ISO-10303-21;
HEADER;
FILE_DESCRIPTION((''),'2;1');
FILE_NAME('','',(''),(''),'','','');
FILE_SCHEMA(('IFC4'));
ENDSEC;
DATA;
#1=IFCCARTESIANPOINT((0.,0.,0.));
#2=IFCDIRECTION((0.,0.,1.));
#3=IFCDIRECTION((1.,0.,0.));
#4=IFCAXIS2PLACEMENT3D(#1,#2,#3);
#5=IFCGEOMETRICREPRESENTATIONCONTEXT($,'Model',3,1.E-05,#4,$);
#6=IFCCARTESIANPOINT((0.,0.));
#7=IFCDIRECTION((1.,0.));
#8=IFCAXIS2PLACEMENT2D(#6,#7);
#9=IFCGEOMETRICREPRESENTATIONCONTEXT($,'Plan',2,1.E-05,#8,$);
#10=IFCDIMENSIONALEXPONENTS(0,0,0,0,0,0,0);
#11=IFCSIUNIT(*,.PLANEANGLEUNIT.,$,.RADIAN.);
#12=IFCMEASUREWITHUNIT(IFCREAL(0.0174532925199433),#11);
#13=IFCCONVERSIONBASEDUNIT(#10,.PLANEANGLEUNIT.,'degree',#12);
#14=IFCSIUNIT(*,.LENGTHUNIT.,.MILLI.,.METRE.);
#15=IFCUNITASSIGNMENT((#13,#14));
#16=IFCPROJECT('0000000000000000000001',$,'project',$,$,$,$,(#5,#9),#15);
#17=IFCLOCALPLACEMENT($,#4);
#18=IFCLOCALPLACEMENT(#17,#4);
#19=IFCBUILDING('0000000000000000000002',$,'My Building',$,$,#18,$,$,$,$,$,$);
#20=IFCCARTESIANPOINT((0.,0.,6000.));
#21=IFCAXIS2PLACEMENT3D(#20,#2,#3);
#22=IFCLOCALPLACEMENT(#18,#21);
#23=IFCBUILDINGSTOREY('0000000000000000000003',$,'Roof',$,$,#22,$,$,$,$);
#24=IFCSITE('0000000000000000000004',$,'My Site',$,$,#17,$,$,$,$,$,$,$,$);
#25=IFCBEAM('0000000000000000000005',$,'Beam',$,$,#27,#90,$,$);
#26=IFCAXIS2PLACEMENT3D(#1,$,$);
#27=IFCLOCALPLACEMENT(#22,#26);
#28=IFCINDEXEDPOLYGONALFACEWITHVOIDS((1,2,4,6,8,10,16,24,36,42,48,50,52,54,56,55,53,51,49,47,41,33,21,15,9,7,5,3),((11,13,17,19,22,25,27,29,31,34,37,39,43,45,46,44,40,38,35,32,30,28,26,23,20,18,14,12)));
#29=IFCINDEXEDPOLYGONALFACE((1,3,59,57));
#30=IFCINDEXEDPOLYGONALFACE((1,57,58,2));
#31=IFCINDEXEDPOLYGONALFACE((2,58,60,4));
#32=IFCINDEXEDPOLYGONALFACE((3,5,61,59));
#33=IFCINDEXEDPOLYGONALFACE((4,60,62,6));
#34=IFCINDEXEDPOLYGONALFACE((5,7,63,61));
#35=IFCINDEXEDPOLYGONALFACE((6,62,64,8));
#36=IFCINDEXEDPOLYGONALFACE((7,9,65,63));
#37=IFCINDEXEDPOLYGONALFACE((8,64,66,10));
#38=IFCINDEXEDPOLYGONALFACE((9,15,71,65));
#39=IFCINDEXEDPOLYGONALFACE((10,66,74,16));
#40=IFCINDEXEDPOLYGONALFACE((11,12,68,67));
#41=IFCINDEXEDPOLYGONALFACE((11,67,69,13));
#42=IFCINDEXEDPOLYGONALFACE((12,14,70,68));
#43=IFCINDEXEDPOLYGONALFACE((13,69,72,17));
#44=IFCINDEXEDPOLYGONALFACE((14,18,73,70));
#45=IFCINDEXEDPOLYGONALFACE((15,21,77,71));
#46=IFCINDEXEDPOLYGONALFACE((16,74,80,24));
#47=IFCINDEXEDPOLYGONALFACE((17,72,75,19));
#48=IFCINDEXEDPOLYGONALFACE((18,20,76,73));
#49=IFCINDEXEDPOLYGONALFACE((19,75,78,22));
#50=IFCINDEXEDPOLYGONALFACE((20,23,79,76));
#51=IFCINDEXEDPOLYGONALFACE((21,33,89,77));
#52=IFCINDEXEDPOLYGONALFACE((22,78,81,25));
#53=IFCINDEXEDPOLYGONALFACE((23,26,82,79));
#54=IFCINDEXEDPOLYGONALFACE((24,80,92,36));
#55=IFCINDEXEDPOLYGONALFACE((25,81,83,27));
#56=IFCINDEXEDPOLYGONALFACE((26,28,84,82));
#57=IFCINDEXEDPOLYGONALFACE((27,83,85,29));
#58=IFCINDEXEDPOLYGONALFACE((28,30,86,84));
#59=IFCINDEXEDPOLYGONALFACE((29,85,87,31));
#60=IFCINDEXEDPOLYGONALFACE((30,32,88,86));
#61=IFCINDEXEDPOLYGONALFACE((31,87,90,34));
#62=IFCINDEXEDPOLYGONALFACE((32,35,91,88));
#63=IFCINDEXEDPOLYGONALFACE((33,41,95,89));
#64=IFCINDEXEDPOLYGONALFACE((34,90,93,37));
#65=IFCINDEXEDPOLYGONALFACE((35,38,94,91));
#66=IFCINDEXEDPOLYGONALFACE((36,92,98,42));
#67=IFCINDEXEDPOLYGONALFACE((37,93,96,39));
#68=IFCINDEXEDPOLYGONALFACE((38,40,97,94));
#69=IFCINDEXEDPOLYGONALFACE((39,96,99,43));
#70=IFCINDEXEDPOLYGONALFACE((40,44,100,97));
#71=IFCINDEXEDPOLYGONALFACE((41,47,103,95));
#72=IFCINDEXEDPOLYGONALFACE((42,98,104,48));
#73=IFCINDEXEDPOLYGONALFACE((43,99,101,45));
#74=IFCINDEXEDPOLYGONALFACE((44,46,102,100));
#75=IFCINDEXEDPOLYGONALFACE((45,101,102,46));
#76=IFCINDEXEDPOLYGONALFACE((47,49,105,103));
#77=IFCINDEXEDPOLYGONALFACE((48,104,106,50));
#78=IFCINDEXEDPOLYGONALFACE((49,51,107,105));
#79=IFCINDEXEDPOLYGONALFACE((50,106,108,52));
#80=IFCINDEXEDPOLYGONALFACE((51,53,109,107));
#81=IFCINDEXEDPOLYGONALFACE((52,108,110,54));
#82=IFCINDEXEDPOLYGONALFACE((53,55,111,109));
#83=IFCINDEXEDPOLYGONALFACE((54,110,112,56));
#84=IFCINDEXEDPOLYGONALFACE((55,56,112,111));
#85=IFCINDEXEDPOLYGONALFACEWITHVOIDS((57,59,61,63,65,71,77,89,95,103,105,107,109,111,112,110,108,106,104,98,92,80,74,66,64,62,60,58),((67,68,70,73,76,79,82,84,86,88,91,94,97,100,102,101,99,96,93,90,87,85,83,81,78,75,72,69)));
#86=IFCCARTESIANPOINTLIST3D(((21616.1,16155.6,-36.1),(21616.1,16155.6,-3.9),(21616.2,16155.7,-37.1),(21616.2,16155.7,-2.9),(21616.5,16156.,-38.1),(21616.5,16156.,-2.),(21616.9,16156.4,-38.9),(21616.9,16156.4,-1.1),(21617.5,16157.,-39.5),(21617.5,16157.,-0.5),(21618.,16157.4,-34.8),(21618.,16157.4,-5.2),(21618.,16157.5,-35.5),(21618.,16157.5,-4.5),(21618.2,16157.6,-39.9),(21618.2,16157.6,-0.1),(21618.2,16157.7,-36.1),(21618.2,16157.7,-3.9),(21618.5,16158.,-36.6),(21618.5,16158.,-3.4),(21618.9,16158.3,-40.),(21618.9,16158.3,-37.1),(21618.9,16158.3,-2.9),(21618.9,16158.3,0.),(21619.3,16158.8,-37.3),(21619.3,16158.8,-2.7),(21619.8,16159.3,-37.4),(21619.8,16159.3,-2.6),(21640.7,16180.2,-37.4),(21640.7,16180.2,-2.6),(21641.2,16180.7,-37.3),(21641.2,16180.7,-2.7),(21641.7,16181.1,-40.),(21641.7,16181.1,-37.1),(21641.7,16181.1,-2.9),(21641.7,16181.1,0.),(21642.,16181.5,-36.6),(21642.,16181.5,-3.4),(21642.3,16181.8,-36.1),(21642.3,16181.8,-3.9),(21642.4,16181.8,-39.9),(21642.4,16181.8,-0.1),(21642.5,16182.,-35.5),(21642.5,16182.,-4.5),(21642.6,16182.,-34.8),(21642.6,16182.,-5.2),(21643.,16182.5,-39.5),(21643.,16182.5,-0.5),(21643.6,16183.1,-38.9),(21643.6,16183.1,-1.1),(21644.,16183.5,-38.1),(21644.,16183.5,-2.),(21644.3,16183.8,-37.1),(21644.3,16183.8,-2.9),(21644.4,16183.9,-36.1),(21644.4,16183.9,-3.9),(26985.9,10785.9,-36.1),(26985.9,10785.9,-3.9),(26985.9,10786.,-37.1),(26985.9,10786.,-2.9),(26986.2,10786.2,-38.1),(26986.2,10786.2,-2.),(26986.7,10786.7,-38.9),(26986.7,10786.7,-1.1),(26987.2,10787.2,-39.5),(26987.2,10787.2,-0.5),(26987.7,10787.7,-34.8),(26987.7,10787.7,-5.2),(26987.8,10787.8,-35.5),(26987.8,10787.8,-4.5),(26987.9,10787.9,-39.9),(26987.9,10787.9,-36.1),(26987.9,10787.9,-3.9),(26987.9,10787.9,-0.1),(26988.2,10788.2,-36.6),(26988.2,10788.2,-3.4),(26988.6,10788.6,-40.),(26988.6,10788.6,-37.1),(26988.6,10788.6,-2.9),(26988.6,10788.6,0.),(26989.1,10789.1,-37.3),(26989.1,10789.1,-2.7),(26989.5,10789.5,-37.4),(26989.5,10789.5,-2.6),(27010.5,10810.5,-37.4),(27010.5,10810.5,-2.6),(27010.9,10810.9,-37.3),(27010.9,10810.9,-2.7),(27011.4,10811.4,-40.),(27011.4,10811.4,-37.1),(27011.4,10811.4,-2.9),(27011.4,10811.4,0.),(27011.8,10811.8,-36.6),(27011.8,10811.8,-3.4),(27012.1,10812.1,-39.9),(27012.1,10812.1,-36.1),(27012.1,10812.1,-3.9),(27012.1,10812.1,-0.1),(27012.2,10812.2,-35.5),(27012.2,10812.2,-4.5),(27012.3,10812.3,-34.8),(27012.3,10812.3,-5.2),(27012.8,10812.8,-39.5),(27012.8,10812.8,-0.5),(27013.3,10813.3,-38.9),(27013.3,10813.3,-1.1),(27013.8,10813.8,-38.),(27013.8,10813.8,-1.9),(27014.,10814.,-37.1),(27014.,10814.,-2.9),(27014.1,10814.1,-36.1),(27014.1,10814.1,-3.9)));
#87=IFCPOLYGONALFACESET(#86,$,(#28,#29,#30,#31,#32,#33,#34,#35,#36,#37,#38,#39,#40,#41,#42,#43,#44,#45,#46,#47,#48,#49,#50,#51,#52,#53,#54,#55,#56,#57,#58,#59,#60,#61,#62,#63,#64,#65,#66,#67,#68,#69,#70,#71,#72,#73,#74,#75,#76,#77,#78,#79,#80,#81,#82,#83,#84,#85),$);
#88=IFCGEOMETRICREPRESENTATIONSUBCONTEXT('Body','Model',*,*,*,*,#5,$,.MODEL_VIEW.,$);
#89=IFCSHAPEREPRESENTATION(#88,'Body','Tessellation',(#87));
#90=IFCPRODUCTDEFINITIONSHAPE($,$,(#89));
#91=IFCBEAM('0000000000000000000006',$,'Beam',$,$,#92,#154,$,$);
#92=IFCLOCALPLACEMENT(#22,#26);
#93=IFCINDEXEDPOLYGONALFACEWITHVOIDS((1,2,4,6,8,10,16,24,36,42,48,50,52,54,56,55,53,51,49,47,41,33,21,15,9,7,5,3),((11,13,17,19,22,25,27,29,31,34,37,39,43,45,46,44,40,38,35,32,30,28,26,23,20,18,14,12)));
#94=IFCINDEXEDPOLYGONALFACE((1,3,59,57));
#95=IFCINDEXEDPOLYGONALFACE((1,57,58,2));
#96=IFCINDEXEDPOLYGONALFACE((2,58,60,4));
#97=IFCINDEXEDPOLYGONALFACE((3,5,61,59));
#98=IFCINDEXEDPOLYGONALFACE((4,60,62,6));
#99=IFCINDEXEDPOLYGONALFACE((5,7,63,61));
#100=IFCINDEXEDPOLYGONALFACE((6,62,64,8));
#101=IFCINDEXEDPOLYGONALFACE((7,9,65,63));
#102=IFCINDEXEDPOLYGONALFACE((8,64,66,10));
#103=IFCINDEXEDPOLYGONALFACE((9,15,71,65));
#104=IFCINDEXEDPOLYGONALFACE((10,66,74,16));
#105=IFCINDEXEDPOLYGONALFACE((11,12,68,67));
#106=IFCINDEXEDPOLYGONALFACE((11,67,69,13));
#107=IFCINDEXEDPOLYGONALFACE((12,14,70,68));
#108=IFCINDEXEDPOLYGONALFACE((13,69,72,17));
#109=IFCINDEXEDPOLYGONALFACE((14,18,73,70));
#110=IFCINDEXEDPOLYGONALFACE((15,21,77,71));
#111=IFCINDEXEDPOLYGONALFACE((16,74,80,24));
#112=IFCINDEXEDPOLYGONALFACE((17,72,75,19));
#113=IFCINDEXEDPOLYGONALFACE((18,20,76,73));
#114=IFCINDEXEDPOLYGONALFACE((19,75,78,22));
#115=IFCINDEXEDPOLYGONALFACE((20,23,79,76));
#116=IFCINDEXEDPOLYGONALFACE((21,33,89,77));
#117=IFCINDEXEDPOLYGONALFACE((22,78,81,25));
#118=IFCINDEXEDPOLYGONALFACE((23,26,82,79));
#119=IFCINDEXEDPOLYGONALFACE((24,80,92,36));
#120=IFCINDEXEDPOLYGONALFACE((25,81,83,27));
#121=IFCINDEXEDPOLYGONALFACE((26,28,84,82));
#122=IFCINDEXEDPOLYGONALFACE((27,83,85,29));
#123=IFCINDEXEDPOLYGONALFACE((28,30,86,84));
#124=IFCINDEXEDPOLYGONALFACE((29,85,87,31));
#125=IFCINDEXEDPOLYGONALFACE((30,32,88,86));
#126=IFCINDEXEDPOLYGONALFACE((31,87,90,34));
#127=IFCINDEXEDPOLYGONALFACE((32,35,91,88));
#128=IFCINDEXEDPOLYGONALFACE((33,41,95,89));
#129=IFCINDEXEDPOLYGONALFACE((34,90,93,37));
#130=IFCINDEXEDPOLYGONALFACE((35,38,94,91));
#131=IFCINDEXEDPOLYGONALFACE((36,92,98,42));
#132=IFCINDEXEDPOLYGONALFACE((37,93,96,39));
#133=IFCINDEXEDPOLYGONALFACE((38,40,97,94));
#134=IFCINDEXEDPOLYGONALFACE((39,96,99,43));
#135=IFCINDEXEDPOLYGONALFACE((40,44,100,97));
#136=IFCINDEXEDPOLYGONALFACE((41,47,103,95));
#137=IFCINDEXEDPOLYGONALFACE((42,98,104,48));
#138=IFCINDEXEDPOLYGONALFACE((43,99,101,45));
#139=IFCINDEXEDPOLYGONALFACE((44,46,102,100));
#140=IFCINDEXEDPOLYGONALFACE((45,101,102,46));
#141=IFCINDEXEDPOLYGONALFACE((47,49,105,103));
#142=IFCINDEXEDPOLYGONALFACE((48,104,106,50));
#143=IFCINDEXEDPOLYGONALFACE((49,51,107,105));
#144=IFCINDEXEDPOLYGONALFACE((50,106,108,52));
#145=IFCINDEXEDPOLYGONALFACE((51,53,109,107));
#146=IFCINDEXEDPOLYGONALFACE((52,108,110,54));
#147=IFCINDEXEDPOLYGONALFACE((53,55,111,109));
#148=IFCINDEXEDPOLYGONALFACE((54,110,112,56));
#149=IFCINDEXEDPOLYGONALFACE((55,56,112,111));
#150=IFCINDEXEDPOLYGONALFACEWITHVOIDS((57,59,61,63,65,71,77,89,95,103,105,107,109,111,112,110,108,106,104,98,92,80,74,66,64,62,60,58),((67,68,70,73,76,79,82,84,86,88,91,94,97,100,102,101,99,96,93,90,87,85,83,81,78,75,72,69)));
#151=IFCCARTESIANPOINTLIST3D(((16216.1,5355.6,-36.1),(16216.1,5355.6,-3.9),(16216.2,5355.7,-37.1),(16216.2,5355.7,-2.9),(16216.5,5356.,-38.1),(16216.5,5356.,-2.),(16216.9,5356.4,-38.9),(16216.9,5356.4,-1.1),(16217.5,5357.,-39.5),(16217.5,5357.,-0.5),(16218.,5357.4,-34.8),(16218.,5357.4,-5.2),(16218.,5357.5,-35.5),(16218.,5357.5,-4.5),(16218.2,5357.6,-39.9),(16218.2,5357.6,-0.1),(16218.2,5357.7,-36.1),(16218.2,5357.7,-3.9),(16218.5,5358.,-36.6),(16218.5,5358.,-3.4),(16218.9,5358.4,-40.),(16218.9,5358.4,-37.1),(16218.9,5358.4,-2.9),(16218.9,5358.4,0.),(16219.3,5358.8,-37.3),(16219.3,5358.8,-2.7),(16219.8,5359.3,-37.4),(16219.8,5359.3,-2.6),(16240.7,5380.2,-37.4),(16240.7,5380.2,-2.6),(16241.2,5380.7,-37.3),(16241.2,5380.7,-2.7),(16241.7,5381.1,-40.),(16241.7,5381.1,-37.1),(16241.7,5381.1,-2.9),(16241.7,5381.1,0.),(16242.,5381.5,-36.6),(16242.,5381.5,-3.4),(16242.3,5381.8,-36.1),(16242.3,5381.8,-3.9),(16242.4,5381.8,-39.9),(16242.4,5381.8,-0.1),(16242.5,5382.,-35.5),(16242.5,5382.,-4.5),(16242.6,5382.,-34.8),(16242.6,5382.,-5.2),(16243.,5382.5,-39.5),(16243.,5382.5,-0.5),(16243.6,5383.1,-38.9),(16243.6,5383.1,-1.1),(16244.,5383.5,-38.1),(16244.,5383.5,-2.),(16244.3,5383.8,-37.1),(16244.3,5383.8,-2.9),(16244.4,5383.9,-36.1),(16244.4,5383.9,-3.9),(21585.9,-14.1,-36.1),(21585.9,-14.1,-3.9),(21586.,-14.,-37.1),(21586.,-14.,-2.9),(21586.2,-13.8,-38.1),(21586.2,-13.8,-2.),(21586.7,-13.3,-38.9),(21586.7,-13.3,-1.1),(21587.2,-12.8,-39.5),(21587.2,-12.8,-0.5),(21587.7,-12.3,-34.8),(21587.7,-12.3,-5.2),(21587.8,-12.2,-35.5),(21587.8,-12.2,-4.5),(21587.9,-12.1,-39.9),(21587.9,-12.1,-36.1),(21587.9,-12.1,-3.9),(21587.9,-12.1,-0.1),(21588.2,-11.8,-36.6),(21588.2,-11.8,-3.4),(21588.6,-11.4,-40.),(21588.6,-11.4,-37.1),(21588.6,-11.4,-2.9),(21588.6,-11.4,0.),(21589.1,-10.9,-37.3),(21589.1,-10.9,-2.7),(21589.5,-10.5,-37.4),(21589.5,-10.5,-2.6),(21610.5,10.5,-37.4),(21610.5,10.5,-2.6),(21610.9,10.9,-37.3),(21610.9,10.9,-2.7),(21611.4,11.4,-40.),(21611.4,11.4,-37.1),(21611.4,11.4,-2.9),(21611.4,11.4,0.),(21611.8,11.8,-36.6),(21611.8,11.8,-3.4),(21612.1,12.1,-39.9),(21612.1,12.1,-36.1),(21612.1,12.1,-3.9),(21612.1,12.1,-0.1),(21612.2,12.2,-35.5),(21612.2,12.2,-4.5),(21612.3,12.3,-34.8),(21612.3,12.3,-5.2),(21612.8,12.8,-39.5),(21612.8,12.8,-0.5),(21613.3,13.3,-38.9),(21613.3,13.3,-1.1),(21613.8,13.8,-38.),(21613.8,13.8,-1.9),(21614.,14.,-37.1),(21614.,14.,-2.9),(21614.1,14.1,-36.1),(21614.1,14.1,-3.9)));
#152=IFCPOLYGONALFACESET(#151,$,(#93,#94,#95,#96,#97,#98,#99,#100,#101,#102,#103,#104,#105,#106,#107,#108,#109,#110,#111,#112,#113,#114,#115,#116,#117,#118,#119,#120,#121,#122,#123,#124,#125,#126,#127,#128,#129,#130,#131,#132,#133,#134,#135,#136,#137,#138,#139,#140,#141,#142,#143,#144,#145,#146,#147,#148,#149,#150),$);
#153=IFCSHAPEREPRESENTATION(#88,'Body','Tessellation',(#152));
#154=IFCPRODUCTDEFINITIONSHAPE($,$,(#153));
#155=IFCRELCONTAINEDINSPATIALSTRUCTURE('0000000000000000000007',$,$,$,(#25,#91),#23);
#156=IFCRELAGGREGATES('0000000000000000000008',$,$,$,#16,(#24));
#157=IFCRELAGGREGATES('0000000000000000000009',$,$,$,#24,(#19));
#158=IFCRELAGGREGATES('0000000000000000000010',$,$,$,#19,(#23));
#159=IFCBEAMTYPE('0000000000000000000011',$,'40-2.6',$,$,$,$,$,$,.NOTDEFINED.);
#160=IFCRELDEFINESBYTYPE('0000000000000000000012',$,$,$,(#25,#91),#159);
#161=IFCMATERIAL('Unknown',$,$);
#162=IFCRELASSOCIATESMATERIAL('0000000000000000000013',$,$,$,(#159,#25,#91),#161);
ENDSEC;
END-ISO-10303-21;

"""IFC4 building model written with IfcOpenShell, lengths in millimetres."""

from ifc_helpers import new_model, entity, si_unit, converted_unit, frame, origin_with_axes, origin_2d_with_axis, place, context, subcontext, project, spatial, hollow_rectangle, extrude, material, material_profile, profile_set, profile_usage, type_object, element, save


model = new_model("IFC4")

# Units and contexts
model_context = context("Model", 3, precision=1e-05, world=origin_with_axes())
plan_context = context("Plan", 2, precision=1e-05, world=origin_2d_with_axis())
body_context = subcontext(model_context, "Body", "Model", "MODEL_VIEW")
ifc_project = project(units=[converted_unit("PLANEANGLEUNIT", "degree", entity("IfcReal", 0.0174532925199433), si_unit("PLANEANGLEUNIT", "RADIAN"), dimensions=[0, 0, 0, 0, 0, 0, 0]), si_unit("LENGTHUNIT", "METRE", prefix="MILLI")], contexts=[model_context, plan_context])

# Site, building, storey
site_placement = place(None, origin_with_axes())
site = spatial("IfcSite", under=ifc_project, at=site_placement, Name="My Site")
building_placement = place(site_placement, origin_with_axes())
building = spatial("IfcBuilding", under=site, at=building_placement, Name="My Building")
storey_placement = place(building_placement, frame((0.0, 0.0, 6000.0), z_axis=(0.0, 0.0, 1.0), x_axis=(1.0, 0.0, 0.0)))
storey = spatial("IfcBuildingStorey", under=building, at=storey_placement, Name="Roof")

# Beams
ifc_material = material(Name="Unknown")
ifc_material_profile_1 = material_profile(ifc_material, hollow_rectangle(XDim=40.0, YDim=40.0, WallThickness=2.6, InnerFilletRadius=2.6, OuterFilletRadius=3.9))
ifc_profile_set_1 = profile_set([ifc_material_profile_1])
beam_type_1 = type_object("IfcBeamType", Name="40-2.6", PredefinedType="NOTDEFINED", material=ifc_profile_set_1)
ifc_profile_usage_1 = profile_usage(ifc_profile_set_1, cardinal=8)
beam_1_placement = place(storey_placement, frame((27000.0, 10800.0, 0.0), z_axis=(-0.707107, 0.707107, 0.0), x_axis=(-0.707107, -0.707107, 0.0)))
element("IfcBeam", 1, at=beam_1_placement, inside=storey, type_object=beam_type_1, material=ifc_profile_usage_1, Name="Beam", context=body_context, shape_type="SweptSolid", body=[
    extrude(hollow_rectangle(XDim=40.0, YDim=40.0, WallThickness=2.6, InnerFilletRadius=2.6, OuterFilletRadius=3.9), frame((0.0, -20.0, 0.0), z_axis=(0.0, 0.0, 1.0), x_axis=(1.0, 0.0, 0.0)), (0.0, 0.0, 1.0), 7594.0),
])
ifc_profile_usage_2 = profile_usage(ifc_profile_set_1, cardinal=8)
beam_2_placement = place(storey_placement, frame((21600.0, 0.0, 0.0), z_axis=(-0.707107, 0.707107, 0.0), x_axis=(-0.707107, -0.707107, 0.0)))
element("IfcBeam", 2, at=beam_2_placement, inside=storey, type_object=beam_type_1, material=ifc_profile_usage_2, Name="Beam", context=body_context, shape_type="SweptSolid", body=[
    extrude(hollow_rectangle(XDim=40.0, YDim=40.0, WallThickness=2.6, InnerFilletRadius=2.6, OuterFilletRadius=3.9), frame((0.0, -20.0, 0.0), z_axis=(0.0, 0.0, 1.0), x_axis=(1.0, 0.0, 0.0)), (0.0, 0.0, 1.0), 7594.0),
])

save(model, "model.ifc")
